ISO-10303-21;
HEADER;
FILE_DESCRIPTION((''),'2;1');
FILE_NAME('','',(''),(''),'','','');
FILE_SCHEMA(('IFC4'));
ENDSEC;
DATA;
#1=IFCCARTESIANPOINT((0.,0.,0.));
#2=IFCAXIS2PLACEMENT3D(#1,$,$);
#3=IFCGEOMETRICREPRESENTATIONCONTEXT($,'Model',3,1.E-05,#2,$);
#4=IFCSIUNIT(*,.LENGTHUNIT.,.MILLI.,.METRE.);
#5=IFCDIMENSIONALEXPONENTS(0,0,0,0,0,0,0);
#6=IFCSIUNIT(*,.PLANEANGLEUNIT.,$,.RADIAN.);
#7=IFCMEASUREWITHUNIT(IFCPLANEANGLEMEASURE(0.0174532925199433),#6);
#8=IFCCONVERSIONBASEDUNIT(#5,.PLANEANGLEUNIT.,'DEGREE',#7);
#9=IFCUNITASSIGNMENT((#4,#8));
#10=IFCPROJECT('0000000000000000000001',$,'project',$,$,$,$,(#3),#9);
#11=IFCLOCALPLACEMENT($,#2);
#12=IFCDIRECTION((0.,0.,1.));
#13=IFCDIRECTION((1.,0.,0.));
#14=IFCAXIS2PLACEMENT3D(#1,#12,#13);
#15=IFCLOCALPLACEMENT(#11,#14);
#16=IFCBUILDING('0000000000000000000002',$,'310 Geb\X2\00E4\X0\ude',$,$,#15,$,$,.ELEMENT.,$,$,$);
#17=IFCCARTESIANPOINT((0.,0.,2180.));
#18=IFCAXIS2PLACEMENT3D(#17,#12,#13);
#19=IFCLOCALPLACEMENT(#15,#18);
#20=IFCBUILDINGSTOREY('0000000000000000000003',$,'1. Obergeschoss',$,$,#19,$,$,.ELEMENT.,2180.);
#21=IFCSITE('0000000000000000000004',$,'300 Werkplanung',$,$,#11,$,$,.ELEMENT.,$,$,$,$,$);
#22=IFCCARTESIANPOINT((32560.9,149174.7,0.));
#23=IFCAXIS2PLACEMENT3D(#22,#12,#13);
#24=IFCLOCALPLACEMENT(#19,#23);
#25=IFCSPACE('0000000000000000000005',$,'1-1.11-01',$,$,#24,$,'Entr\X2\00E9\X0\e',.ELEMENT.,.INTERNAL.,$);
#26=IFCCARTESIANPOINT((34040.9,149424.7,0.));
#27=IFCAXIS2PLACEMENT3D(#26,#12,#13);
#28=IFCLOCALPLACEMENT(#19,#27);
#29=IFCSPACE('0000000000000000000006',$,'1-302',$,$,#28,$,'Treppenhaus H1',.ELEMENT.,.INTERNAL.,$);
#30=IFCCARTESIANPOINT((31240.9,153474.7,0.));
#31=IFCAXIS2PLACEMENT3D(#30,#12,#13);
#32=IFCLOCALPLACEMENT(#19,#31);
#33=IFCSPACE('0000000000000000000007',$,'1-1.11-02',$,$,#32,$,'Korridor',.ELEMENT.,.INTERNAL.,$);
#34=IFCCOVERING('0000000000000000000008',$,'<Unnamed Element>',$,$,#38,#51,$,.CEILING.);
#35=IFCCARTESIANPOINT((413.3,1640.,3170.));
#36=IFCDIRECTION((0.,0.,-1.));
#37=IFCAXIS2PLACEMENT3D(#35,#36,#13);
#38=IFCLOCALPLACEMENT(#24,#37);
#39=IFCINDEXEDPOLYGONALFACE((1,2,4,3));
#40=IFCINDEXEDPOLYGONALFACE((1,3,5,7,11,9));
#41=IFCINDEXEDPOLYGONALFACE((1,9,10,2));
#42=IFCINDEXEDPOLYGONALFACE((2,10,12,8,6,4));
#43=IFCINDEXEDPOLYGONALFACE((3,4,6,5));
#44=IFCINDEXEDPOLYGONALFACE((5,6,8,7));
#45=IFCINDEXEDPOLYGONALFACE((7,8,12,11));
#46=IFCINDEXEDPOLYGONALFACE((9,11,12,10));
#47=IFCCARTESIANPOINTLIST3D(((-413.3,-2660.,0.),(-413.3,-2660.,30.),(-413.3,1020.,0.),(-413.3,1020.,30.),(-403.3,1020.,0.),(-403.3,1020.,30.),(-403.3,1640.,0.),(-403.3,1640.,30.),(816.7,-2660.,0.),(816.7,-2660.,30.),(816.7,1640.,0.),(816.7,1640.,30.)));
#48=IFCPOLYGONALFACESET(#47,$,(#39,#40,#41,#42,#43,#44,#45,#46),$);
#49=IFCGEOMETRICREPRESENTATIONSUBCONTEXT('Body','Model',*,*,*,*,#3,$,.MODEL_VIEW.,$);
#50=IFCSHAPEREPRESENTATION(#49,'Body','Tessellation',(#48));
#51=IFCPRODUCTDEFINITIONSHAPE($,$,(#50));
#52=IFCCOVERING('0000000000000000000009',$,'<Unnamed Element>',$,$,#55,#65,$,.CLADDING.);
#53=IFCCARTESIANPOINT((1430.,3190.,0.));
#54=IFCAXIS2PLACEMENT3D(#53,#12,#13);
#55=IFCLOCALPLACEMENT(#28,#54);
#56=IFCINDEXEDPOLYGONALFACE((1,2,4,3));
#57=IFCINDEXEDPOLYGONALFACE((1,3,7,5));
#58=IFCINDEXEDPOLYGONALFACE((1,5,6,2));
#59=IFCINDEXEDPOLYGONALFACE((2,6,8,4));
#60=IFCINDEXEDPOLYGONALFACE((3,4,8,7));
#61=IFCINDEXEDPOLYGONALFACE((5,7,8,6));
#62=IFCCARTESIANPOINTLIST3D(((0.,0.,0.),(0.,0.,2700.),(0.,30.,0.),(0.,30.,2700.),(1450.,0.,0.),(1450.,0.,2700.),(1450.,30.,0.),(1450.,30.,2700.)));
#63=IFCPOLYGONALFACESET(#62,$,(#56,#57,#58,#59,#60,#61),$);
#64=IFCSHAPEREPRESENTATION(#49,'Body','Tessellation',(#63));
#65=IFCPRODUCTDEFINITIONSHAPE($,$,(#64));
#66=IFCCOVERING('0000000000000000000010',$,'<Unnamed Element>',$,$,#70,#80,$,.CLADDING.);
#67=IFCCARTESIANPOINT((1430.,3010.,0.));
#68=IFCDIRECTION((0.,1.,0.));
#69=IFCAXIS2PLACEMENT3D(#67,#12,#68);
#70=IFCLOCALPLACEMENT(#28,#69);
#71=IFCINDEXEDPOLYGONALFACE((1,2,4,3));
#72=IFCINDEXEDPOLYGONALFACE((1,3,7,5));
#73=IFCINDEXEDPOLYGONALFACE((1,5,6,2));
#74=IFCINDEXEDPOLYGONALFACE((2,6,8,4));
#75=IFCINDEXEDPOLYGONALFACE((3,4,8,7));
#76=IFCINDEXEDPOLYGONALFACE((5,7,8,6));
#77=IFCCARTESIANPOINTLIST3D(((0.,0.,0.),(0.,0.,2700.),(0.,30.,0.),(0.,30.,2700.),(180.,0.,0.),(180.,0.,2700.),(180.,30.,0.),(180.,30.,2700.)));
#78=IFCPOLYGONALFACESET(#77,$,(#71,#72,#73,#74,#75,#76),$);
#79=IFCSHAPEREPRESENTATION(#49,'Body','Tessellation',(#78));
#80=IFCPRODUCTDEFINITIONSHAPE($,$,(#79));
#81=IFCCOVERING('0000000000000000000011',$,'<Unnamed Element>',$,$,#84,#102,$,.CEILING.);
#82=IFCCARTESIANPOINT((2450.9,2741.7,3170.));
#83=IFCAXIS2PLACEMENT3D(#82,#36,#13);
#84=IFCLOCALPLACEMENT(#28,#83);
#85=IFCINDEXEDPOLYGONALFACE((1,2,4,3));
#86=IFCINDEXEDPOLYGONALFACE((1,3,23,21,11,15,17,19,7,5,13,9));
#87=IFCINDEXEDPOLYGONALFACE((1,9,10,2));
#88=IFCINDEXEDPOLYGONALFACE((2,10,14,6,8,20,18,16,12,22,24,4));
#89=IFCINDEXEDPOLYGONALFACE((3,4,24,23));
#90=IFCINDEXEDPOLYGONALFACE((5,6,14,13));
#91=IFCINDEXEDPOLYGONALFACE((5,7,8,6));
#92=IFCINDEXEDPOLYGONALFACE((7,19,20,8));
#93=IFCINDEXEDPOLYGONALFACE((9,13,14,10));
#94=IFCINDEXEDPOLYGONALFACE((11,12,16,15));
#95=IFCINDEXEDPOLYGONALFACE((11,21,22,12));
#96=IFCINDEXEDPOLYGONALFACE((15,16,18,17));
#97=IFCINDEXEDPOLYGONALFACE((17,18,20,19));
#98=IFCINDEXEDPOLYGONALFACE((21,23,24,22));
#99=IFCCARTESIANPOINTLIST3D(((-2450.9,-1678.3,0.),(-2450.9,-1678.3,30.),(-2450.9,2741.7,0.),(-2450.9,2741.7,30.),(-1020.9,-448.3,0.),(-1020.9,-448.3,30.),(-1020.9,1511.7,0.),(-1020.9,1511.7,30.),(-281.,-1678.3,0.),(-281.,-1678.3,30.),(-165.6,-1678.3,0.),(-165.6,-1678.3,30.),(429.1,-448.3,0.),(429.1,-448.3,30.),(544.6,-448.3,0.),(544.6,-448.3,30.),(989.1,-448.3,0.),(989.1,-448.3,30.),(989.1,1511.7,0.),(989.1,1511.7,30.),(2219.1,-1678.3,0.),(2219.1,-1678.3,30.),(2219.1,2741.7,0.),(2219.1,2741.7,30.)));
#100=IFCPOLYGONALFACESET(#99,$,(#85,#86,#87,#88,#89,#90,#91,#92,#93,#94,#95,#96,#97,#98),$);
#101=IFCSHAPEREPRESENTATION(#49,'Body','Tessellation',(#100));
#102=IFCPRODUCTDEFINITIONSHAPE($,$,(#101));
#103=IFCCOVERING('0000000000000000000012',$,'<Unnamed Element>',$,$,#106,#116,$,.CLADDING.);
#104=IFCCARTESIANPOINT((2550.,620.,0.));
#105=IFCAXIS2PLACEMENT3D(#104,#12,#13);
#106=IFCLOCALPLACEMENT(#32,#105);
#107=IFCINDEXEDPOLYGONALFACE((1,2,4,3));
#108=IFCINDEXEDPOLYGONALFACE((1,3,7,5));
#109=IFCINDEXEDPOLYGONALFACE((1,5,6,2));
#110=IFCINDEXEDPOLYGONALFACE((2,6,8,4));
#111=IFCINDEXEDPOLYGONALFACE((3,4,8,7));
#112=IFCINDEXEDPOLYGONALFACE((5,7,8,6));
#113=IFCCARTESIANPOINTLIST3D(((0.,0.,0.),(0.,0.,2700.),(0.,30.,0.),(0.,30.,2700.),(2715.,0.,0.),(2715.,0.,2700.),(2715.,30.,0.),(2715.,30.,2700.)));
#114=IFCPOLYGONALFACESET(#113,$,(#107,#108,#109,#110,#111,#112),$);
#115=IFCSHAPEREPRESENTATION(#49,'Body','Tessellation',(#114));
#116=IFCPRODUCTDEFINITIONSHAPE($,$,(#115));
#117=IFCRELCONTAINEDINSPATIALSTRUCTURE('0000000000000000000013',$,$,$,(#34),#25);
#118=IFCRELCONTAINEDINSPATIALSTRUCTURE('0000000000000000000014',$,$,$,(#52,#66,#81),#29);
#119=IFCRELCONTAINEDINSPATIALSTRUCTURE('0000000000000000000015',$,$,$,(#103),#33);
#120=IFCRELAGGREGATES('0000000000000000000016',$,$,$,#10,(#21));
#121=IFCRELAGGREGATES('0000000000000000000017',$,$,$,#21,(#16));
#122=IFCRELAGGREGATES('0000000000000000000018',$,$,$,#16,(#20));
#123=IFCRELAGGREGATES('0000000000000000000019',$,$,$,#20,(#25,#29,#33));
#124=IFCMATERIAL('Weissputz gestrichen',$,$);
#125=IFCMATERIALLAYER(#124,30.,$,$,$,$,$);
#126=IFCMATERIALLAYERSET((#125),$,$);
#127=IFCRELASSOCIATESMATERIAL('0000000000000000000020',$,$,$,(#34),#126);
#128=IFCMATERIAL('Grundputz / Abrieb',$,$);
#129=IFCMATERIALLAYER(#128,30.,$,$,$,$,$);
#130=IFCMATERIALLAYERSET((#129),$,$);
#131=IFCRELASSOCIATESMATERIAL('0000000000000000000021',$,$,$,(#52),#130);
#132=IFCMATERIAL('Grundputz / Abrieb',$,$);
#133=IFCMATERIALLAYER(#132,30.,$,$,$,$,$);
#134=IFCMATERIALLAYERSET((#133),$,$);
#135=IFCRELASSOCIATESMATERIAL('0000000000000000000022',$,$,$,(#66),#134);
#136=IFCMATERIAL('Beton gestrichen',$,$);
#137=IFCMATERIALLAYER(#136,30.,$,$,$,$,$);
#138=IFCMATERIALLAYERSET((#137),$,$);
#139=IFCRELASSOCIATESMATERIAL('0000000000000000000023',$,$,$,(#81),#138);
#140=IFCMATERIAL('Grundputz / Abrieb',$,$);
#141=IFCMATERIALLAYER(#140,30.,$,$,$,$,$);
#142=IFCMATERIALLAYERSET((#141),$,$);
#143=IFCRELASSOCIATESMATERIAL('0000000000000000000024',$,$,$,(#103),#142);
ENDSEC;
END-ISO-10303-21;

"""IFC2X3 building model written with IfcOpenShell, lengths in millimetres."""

from ifc_helpers import new_model, entity, si_unit, converted_unit, frame, frame_2d, origin, origin_with_axes, place, context, subcontext, project, spatial, polyline, rectangle, outline, extrude, material, layer, layer_set, layer_usage, element, save


model = new_model("IFC2X3")

# Units and contexts
model_context = context("Model", 3, precision=1e-05, world=origin())
body_context = subcontext(model_context, "Body", "Model", "MODEL_VIEW")
ifc_project = project(units=[si_unit("LENGTHUNIT", "METRE", prefix="MILLI"), converted_unit("PLANEANGLEUNIT", "DEGREE", entity("IfcPlaneAngleMeasure", 0.0174532925199433), si_unit("PLANEANGLEUNIT", "RADIAN"), dimensions=[0, 0, 0, 0, 0, 0, 0])], contexts=[model_context])

# Site, building, storey
site_placement = place(None, origin())
site = spatial("IfcSite", under=ifc_project, at=site_placement, Name="300 Werkplanung", CompositionType="ELEMENT")
building_placement = place(site_placement, origin_with_axes())
building = spatial("IfcBuilding", under=site, at=building_placement, Name="310 Gebäude", CompositionType="ELEMENT")
storey_placement = place(building_placement, frame((0.0, 0.0, 2180.0), z_axis=(0.0, 0.0, 1.0), x_axis=(1.0, 0.0, 0.0)))
storey = spatial("IfcBuildingStorey", under=building, at=storey_placement, Name="1. Obergeschoss", CompositionType="ELEMENT", Elevation=2180.0)

# Shared definitions
space_1_placement = place(storey_placement, frame((32560.9, 149174.7, 0.0), z_axis=(0.0, 0.0, 1.0), x_axis=(1.0, 0.0, 0.0)))
space_1 = spatial("IfcSpace", under=storey, at=space_1_placement, Name="1-1.11-01", LongName="Entrée", CompositionType="ELEMENT", InteriorOrExteriorSpace="INTERNAL")

# Covering
ifc_material_1 = material(Name="Weissputz gestrichen")
ifc_layer_1 = layer(ifc_material_1, 30.0)
ifc_layer_set_1 = layer_set([ifc_layer_1])
ifc_layer_usage_1 = layer_usage(ifc_layer_set_1, "AXIS3", "POSITIVE", 0.0)
covering_1_placement = place(space_1_placement, frame((413.3, 1640.0, 3170.0), z_axis=(0.0, 0.0, -1.0), x_axis=(1.0, 0.0, 0.0)))
element("IfcCovering", 1, at=covering_1_placement, inside=space_1, material=ifc_layer_usage_1, Name="<Unnamed Element>", PredefinedType="CEILING", context=body_context, shape_type="SweptSolid", body=[
    extrude(outline(polyline([(-413.3, -2660.0), (816.7, -2660.0), (816.7, 1640.0), (-403.3, 1640.0), (-403.3, 1020.0), (-413.3, 1020.0), (-413.3, -2660.0)])), origin_with_axes(), (0.0, 0.0, 1.0), 30.0),
])

# Shared definitions
space_2_placement = place(storey_placement, frame((34040.9, 149424.7, 0.0), z_axis=(0.0, 0.0, 1.0), x_axis=(1.0, 0.0, 0.0)))
space_2 = spatial("IfcSpace", under=storey, at=space_2_placement, Name="1-302", LongName="Treppenhaus H1", CompositionType="ELEMENT", InteriorOrExteriorSpace="INTERNAL")

# Coverings
ifc_material_2 = material(Name="Grundputz / Abrieb")
ifc_layer_2 = layer(ifc_material_2, 30.0)
ifc_layer_set_2 = layer_set([ifc_layer_2])
ifc_layer_usage_2 = layer_usage(ifc_layer_set_2, "AXIS3", "POSITIVE", 0.0)
covering_2_placement = place(space_2_placement, frame((1430.0, 3190.0, 0.0), z_axis=(0.0, 0.0, 1.0), x_axis=(1.0, 0.0, 0.0)))
element("IfcCovering", 2, at=covering_2_placement, inside=space_2, material=ifc_layer_usage_2, Name="<Unnamed Element>", PredefinedType="CLADDING", context=body_context, shape_type="SweptSolid", body=[
    extrude(rectangle(XDim=2700.0, YDim=1450.0, at=frame_2d((-725.0, 1350.0), x_axis=(0.0, 1.0))), frame((1450.0, 0.0, 2700.0), z_axis=(0.0, 1.0, 0.0), x_axis=(1.0, 0.0, 0.0)), (0.0, 0.0, 1.0), 30.0),
])
ifc_material_3 = material(Name="Grundputz / Abrieb")
ifc_layer_3 = layer(ifc_material_3, 30.0)
ifc_layer_set_3 = layer_set([ifc_layer_3])
ifc_layer_usage_3 = layer_usage(ifc_layer_set_3, "AXIS3", "POSITIVE", 0.0)
covering_3_placement = place(space_2_placement, frame((1430.0, 3010.0, 0.0), z_axis=(0.0, 0.0, 1.0), x_axis=(0.0, 1.0, 0.0)))
element("IfcCovering", 3, at=covering_3_placement, inside=space_2, material=ifc_layer_usage_3, Name="<Unnamed Element>", PredefinedType="CLADDING", context=body_context, shape_type="SweptSolid", body=[
    extrude(rectangle(XDim=2700.0, YDim=180.0, at=frame_2d((-90.0, 1350.0), x_axis=(0.0, 1.0))), frame((180.0, 0.0, 2700.0), z_axis=(0.0, 1.0, 0.0), x_axis=(1.0, 0.0, 0.0)), (0.0, 0.0, 1.0), 30.0),
])
ifc_material_4 = material(Name="Beton gestrichen")
ifc_layer_4 = layer(ifc_material_4, 30.0)
ifc_layer_set_4 = layer_set([ifc_layer_4])
ifc_layer_usage_4 = layer_usage(ifc_layer_set_4, "AXIS3", "POSITIVE", 0.0)
covering_4_placement = place(space_2_placement, frame((2450.9, 2741.7, 3170.0), z_axis=(0.0, 0.0, -1.0), x_axis=(1.0, 0.0, 0.0)))
element("IfcCovering", 4, at=covering_4_placement, inside=space_2, material=ifc_layer_usage_4, Name="<Unnamed Element>", PredefinedType="CEILING", context=body_context, shape_type="SweptSolid", body=[
    extrude(outline(polyline([(-2450.9, -1678.3), (-281.0, -1678.3), (429.1, -448.3), (-1020.9, -448.3), (-1020.9, 1511.7), (989.1, 1511.7), (989.1, -448.3), (544.6, -448.3), (-165.6, -1678.3), (2219.1, -1678.3), (2219.1, 2741.7), (-2450.9, 2741.7), (-2450.9, -1678.3)])), origin_with_axes(), (0.0, 0.0, 1.0), 30.0),
])

# Shared definitions
space_3_placement = place(storey_placement, frame((31240.9, 153474.7, 0.0), z_axis=(0.0, 0.0, 1.0), x_axis=(1.0, 0.0, 0.0)))
space_3 = spatial("IfcSpace", under=storey, at=space_3_placement, Name="1-1.11-02", LongName="Korridor", CompositionType="ELEMENT", InteriorOrExteriorSpace="INTERNAL")

# Covering
ifc_material_5 = material(Name="Grundputz / Abrieb")
ifc_layer_5 = layer(ifc_material_5, 30.0)
ifc_layer_set_5 = layer_set([ifc_layer_5])
ifc_layer_usage_5 = layer_usage(ifc_layer_set_5, "AXIS3", "POSITIVE", 0.0)
covering_5_placement = place(space_3_placement, frame((2550.0, 620.0, 0.0), z_axis=(0.0, 0.0, 1.0), x_axis=(1.0, 0.0, 0.0)))
element("IfcCovering", 5, at=covering_5_placement, inside=space_3, material=ifc_layer_usage_5, Name="<Unnamed Element>", PredefinedType="CLADDING", context=body_context, shape_type="SweptSolid", body=[
    extrude(rectangle(XDim=2700.0, YDim=2715.0, at=frame_2d((-1357.5, 1350.0), x_axis=(0.0, 1.0))), frame((2715.0, 0.0, 2700.0), z_axis=(0.0, 1.0, 0.0), x_axis=(1.0, 0.0, 0.0)), (0.0, 0.0, 1.0), 30.0),
])

save(model, "model.ifc")
